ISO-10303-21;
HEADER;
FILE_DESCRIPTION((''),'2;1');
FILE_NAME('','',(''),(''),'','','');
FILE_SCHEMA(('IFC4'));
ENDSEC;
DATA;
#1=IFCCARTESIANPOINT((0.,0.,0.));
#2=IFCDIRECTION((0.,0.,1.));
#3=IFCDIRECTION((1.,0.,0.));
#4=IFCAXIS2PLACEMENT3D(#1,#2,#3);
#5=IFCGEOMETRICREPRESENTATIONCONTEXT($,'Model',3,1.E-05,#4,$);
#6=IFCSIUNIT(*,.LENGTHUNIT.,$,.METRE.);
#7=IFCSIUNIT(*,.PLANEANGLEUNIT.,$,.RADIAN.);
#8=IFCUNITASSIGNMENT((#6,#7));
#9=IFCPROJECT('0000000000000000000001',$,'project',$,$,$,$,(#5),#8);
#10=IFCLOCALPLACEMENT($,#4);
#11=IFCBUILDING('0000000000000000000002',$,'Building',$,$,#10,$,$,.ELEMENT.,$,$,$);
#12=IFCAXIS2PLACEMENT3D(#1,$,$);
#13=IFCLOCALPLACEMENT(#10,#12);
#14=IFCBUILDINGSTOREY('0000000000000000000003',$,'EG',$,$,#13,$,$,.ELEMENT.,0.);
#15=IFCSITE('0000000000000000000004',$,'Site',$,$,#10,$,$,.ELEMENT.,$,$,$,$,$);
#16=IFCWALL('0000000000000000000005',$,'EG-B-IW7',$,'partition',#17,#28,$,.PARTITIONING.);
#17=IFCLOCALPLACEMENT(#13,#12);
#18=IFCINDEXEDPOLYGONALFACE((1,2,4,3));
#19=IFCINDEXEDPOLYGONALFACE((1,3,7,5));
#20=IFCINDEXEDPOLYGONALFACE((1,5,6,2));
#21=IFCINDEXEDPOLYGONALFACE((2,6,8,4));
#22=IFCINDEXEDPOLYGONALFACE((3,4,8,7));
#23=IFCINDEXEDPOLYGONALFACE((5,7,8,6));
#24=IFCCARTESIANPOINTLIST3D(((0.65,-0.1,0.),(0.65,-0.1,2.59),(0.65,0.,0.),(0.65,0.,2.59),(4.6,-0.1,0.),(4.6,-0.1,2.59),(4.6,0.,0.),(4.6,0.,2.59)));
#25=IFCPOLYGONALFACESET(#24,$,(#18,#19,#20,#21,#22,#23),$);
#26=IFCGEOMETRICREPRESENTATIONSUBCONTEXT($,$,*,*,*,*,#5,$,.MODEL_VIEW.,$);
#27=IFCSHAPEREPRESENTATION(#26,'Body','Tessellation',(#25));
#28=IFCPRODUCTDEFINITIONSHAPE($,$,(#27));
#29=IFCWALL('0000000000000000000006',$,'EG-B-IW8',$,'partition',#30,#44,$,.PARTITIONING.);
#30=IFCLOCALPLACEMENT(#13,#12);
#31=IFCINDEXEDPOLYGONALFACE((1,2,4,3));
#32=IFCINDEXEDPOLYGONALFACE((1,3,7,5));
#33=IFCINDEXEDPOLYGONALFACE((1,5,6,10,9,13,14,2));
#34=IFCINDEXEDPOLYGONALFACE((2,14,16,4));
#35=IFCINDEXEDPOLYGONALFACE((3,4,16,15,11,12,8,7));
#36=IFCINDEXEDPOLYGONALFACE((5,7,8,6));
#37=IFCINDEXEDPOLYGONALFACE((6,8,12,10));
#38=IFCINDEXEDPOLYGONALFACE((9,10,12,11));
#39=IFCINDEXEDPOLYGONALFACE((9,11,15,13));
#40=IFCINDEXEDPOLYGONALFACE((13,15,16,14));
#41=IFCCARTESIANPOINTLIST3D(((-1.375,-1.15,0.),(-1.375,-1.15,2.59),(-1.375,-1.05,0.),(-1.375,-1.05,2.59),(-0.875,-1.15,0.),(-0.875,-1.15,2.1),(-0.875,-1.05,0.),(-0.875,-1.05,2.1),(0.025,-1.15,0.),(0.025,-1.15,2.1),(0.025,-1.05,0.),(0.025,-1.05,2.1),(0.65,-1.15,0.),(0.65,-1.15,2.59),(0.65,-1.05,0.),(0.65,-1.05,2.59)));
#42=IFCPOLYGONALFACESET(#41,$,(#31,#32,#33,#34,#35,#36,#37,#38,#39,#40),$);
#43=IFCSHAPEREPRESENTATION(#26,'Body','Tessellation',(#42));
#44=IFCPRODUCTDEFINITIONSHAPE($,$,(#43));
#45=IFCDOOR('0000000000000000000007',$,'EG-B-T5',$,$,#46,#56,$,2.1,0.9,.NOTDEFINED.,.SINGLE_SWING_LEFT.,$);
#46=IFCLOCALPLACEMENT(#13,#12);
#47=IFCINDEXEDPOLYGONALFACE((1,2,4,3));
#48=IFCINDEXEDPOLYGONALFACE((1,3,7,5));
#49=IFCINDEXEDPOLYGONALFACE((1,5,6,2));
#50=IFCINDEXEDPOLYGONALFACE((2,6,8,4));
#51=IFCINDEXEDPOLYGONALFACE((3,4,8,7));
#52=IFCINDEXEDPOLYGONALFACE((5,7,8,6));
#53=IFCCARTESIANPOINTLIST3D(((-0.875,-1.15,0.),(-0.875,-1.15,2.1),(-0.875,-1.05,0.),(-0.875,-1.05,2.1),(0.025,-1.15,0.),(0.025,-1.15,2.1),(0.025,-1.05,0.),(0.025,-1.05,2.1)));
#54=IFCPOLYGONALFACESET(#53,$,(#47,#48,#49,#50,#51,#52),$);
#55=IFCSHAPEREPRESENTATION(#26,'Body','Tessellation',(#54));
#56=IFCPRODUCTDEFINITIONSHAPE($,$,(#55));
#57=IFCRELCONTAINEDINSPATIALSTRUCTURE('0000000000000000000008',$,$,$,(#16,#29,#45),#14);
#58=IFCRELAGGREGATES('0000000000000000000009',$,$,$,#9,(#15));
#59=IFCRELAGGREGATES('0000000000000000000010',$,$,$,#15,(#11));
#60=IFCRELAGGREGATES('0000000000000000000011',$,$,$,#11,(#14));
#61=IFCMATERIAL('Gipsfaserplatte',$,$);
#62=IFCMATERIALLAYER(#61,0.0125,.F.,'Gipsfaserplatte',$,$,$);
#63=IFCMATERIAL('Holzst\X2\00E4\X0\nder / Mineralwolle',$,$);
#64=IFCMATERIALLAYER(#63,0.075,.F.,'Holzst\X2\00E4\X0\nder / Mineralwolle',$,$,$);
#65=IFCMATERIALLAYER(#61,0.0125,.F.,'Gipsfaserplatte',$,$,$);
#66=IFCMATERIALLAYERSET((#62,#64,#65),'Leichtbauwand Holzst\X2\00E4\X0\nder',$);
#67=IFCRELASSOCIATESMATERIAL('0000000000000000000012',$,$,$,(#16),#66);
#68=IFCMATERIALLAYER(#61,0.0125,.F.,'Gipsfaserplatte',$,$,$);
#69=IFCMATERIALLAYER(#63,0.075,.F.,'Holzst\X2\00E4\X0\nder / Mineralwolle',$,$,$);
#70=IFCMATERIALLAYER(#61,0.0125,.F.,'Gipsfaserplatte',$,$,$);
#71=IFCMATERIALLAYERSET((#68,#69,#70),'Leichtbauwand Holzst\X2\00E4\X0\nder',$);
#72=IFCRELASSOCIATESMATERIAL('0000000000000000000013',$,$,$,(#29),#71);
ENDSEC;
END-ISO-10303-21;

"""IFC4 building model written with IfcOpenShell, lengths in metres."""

from ifc_helpers import new_model, si_unit, frame, frame_2d, origin, origin_with_axes, place, context, subcontext, project, spatial, rectangle, extrude, material, layer, layer_set, element, fill, save


model = new_model("IFC4")

# Units and contexts
model_context = context("Model", 3, precision=1e-05, world=origin_with_axes())
sub_context = subcontext(model_context, None, None, "MODEL_VIEW")
ifc_project = project(units=[si_unit("LENGTHUNIT", "METRE"), si_unit("PLANEANGLEUNIT", "RADIAN")], contexts=[model_context])

# Site, building, storey
placement = place(None, origin_with_axes())
site = spatial("IfcSite", under=ifc_project, at=placement, Name="Site", CompositionType="ELEMENT")
building = spatial("IfcBuilding", under=site, at=placement, Name="Building", CompositionType="ELEMENT")
storey_placement = place(placement, origin())
storey = spatial("IfcBuildingStorey", under=building, at=storey_placement, Name="EG", CompositionType="ELEMENT", Elevation=0.0)

# Shared definitions
ifc_material_1 = material(Name="Gipsfaserplatte")

# Wall
ifc_material_2 = material(Name="Holzständer / Mineralwolle")
ifc_layer_1 = layer(ifc_material_1, 0.0125, ventilated=False, Name="Gipsfaserplatte")
ifc_layer_2 = layer(ifc_material_2, 0.075, ventilated=False, Name="Holzständer / Mineralwolle")
ifc_layer_3 = layer(ifc_material_1, 0.0125, ventilated=False, Name="Gipsfaserplatte")
ifc_layer_set_1 = layer_set([ifc_layer_1, ifc_layer_2, ifc_layer_3], Name="Leichtbauwand Holzständer")
wall_1_placement = place(storey_placement, frame((0.65, -0.05, 0.0), z_axis=(0.0, 0.0, 1.0), x_axis=(1.0, 0.0, 0.0)))
element("IfcWall", 1, at=wall_1_placement, inside=storey, material=ifc_layer_set_1, Name="EG-B-IW7", ObjectType="partition", PredefinedType="PARTITIONING", context=sub_context, shape_type="SweptSolid", body=[
    extrude(rectangle(XDim=3.95, YDim=0.1, at=frame_2d((1.975, 0.0))), origin(), (0.0, 0.0, 1.0), 2.59),
])

# Wall, opening, door
ifc_layer_4 = layer(ifc_material_1, 0.0125, ventilated=False, Name="Gipsfaserplatte")
ifc_layer_5 = layer(ifc_material_2, 0.075, ventilated=False, Name="Holzständer / Mineralwolle")
ifc_layer_6 = layer(ifc_material_1, 0.0125, ventilated=False, Name="Gipsfaserplatte")
ifc_layer_set_2 = layer_set([ifc_layer_4, ifc_layer_5, ifc_layer_6], Name="Leichtbauwand Holzständer")
wall_2_placement = place(storey_placement, frame((-1.375, -1.1, 0.0), z_axis=(0.0, 0.0, 1.0), x_axis=(1.0, 0.0, 0.0)))
wall_2 = element("IfcWall", 2, at=wall_2_placement, inside=storey, material=ifc_layer_set_2, Name="EG-B-IW8", ObjectType="partition", PredefinedType="PARTITIONING", context=sub_context, shape_type="SweptSolid", body=[
    extrude(rectangle(XDim=2.025, YDim=0.1, at=frame_2d((1.0125, 0.0))), origin(), (0.0, 0.0, 1.0), 2.59),
])
opening_1_placement = place(wall_2_placement, frame((0.95, 0.1, 0.0), z_axis=(0.0, -1.0, 0.0), x_axis=(1.0, 0.0, 0.0)))
opening_1 = element("IfcOpeningElement", 3, at=opening_1_placement, cuts=wall_2, PredefinedType="OPENING", context=sub_context, shape_type="SweptSolid", body=[
    extrude(rectangle(XDim=0.9, YDim=2.1, at=frame_2d((0.0, 1.05))), origin(), (0.0, 0.0, 1.0), 0.2),
])
door_1_placement = place(wall_2_placement, frame((0.95, 0.05, 0.0), z_axis=(0.0, -1.0, 0.0), x_axis=(1.0, 0.0, 0.0)))
door_1 = element("IfcDoor", 4, at=door_1_placement, inside=storey, Name="EG-B-T5", OperationType="SINGLE_SWING_LEFT", OverallHeight=2.1, OverallWidth=0.9, PredefinedType="NOTDEFINED", context=sub_context, shape_type="SweptSolid", body=[
    extrude(rectangle(XDim=0.9, YDim=2.1, at=frame_2d((0.0, 1.05))), origin(), (0.0, 0.0, 1.0), 0.1),
])
fill(opening_1, door_1)

save(model, "model.ifc")
